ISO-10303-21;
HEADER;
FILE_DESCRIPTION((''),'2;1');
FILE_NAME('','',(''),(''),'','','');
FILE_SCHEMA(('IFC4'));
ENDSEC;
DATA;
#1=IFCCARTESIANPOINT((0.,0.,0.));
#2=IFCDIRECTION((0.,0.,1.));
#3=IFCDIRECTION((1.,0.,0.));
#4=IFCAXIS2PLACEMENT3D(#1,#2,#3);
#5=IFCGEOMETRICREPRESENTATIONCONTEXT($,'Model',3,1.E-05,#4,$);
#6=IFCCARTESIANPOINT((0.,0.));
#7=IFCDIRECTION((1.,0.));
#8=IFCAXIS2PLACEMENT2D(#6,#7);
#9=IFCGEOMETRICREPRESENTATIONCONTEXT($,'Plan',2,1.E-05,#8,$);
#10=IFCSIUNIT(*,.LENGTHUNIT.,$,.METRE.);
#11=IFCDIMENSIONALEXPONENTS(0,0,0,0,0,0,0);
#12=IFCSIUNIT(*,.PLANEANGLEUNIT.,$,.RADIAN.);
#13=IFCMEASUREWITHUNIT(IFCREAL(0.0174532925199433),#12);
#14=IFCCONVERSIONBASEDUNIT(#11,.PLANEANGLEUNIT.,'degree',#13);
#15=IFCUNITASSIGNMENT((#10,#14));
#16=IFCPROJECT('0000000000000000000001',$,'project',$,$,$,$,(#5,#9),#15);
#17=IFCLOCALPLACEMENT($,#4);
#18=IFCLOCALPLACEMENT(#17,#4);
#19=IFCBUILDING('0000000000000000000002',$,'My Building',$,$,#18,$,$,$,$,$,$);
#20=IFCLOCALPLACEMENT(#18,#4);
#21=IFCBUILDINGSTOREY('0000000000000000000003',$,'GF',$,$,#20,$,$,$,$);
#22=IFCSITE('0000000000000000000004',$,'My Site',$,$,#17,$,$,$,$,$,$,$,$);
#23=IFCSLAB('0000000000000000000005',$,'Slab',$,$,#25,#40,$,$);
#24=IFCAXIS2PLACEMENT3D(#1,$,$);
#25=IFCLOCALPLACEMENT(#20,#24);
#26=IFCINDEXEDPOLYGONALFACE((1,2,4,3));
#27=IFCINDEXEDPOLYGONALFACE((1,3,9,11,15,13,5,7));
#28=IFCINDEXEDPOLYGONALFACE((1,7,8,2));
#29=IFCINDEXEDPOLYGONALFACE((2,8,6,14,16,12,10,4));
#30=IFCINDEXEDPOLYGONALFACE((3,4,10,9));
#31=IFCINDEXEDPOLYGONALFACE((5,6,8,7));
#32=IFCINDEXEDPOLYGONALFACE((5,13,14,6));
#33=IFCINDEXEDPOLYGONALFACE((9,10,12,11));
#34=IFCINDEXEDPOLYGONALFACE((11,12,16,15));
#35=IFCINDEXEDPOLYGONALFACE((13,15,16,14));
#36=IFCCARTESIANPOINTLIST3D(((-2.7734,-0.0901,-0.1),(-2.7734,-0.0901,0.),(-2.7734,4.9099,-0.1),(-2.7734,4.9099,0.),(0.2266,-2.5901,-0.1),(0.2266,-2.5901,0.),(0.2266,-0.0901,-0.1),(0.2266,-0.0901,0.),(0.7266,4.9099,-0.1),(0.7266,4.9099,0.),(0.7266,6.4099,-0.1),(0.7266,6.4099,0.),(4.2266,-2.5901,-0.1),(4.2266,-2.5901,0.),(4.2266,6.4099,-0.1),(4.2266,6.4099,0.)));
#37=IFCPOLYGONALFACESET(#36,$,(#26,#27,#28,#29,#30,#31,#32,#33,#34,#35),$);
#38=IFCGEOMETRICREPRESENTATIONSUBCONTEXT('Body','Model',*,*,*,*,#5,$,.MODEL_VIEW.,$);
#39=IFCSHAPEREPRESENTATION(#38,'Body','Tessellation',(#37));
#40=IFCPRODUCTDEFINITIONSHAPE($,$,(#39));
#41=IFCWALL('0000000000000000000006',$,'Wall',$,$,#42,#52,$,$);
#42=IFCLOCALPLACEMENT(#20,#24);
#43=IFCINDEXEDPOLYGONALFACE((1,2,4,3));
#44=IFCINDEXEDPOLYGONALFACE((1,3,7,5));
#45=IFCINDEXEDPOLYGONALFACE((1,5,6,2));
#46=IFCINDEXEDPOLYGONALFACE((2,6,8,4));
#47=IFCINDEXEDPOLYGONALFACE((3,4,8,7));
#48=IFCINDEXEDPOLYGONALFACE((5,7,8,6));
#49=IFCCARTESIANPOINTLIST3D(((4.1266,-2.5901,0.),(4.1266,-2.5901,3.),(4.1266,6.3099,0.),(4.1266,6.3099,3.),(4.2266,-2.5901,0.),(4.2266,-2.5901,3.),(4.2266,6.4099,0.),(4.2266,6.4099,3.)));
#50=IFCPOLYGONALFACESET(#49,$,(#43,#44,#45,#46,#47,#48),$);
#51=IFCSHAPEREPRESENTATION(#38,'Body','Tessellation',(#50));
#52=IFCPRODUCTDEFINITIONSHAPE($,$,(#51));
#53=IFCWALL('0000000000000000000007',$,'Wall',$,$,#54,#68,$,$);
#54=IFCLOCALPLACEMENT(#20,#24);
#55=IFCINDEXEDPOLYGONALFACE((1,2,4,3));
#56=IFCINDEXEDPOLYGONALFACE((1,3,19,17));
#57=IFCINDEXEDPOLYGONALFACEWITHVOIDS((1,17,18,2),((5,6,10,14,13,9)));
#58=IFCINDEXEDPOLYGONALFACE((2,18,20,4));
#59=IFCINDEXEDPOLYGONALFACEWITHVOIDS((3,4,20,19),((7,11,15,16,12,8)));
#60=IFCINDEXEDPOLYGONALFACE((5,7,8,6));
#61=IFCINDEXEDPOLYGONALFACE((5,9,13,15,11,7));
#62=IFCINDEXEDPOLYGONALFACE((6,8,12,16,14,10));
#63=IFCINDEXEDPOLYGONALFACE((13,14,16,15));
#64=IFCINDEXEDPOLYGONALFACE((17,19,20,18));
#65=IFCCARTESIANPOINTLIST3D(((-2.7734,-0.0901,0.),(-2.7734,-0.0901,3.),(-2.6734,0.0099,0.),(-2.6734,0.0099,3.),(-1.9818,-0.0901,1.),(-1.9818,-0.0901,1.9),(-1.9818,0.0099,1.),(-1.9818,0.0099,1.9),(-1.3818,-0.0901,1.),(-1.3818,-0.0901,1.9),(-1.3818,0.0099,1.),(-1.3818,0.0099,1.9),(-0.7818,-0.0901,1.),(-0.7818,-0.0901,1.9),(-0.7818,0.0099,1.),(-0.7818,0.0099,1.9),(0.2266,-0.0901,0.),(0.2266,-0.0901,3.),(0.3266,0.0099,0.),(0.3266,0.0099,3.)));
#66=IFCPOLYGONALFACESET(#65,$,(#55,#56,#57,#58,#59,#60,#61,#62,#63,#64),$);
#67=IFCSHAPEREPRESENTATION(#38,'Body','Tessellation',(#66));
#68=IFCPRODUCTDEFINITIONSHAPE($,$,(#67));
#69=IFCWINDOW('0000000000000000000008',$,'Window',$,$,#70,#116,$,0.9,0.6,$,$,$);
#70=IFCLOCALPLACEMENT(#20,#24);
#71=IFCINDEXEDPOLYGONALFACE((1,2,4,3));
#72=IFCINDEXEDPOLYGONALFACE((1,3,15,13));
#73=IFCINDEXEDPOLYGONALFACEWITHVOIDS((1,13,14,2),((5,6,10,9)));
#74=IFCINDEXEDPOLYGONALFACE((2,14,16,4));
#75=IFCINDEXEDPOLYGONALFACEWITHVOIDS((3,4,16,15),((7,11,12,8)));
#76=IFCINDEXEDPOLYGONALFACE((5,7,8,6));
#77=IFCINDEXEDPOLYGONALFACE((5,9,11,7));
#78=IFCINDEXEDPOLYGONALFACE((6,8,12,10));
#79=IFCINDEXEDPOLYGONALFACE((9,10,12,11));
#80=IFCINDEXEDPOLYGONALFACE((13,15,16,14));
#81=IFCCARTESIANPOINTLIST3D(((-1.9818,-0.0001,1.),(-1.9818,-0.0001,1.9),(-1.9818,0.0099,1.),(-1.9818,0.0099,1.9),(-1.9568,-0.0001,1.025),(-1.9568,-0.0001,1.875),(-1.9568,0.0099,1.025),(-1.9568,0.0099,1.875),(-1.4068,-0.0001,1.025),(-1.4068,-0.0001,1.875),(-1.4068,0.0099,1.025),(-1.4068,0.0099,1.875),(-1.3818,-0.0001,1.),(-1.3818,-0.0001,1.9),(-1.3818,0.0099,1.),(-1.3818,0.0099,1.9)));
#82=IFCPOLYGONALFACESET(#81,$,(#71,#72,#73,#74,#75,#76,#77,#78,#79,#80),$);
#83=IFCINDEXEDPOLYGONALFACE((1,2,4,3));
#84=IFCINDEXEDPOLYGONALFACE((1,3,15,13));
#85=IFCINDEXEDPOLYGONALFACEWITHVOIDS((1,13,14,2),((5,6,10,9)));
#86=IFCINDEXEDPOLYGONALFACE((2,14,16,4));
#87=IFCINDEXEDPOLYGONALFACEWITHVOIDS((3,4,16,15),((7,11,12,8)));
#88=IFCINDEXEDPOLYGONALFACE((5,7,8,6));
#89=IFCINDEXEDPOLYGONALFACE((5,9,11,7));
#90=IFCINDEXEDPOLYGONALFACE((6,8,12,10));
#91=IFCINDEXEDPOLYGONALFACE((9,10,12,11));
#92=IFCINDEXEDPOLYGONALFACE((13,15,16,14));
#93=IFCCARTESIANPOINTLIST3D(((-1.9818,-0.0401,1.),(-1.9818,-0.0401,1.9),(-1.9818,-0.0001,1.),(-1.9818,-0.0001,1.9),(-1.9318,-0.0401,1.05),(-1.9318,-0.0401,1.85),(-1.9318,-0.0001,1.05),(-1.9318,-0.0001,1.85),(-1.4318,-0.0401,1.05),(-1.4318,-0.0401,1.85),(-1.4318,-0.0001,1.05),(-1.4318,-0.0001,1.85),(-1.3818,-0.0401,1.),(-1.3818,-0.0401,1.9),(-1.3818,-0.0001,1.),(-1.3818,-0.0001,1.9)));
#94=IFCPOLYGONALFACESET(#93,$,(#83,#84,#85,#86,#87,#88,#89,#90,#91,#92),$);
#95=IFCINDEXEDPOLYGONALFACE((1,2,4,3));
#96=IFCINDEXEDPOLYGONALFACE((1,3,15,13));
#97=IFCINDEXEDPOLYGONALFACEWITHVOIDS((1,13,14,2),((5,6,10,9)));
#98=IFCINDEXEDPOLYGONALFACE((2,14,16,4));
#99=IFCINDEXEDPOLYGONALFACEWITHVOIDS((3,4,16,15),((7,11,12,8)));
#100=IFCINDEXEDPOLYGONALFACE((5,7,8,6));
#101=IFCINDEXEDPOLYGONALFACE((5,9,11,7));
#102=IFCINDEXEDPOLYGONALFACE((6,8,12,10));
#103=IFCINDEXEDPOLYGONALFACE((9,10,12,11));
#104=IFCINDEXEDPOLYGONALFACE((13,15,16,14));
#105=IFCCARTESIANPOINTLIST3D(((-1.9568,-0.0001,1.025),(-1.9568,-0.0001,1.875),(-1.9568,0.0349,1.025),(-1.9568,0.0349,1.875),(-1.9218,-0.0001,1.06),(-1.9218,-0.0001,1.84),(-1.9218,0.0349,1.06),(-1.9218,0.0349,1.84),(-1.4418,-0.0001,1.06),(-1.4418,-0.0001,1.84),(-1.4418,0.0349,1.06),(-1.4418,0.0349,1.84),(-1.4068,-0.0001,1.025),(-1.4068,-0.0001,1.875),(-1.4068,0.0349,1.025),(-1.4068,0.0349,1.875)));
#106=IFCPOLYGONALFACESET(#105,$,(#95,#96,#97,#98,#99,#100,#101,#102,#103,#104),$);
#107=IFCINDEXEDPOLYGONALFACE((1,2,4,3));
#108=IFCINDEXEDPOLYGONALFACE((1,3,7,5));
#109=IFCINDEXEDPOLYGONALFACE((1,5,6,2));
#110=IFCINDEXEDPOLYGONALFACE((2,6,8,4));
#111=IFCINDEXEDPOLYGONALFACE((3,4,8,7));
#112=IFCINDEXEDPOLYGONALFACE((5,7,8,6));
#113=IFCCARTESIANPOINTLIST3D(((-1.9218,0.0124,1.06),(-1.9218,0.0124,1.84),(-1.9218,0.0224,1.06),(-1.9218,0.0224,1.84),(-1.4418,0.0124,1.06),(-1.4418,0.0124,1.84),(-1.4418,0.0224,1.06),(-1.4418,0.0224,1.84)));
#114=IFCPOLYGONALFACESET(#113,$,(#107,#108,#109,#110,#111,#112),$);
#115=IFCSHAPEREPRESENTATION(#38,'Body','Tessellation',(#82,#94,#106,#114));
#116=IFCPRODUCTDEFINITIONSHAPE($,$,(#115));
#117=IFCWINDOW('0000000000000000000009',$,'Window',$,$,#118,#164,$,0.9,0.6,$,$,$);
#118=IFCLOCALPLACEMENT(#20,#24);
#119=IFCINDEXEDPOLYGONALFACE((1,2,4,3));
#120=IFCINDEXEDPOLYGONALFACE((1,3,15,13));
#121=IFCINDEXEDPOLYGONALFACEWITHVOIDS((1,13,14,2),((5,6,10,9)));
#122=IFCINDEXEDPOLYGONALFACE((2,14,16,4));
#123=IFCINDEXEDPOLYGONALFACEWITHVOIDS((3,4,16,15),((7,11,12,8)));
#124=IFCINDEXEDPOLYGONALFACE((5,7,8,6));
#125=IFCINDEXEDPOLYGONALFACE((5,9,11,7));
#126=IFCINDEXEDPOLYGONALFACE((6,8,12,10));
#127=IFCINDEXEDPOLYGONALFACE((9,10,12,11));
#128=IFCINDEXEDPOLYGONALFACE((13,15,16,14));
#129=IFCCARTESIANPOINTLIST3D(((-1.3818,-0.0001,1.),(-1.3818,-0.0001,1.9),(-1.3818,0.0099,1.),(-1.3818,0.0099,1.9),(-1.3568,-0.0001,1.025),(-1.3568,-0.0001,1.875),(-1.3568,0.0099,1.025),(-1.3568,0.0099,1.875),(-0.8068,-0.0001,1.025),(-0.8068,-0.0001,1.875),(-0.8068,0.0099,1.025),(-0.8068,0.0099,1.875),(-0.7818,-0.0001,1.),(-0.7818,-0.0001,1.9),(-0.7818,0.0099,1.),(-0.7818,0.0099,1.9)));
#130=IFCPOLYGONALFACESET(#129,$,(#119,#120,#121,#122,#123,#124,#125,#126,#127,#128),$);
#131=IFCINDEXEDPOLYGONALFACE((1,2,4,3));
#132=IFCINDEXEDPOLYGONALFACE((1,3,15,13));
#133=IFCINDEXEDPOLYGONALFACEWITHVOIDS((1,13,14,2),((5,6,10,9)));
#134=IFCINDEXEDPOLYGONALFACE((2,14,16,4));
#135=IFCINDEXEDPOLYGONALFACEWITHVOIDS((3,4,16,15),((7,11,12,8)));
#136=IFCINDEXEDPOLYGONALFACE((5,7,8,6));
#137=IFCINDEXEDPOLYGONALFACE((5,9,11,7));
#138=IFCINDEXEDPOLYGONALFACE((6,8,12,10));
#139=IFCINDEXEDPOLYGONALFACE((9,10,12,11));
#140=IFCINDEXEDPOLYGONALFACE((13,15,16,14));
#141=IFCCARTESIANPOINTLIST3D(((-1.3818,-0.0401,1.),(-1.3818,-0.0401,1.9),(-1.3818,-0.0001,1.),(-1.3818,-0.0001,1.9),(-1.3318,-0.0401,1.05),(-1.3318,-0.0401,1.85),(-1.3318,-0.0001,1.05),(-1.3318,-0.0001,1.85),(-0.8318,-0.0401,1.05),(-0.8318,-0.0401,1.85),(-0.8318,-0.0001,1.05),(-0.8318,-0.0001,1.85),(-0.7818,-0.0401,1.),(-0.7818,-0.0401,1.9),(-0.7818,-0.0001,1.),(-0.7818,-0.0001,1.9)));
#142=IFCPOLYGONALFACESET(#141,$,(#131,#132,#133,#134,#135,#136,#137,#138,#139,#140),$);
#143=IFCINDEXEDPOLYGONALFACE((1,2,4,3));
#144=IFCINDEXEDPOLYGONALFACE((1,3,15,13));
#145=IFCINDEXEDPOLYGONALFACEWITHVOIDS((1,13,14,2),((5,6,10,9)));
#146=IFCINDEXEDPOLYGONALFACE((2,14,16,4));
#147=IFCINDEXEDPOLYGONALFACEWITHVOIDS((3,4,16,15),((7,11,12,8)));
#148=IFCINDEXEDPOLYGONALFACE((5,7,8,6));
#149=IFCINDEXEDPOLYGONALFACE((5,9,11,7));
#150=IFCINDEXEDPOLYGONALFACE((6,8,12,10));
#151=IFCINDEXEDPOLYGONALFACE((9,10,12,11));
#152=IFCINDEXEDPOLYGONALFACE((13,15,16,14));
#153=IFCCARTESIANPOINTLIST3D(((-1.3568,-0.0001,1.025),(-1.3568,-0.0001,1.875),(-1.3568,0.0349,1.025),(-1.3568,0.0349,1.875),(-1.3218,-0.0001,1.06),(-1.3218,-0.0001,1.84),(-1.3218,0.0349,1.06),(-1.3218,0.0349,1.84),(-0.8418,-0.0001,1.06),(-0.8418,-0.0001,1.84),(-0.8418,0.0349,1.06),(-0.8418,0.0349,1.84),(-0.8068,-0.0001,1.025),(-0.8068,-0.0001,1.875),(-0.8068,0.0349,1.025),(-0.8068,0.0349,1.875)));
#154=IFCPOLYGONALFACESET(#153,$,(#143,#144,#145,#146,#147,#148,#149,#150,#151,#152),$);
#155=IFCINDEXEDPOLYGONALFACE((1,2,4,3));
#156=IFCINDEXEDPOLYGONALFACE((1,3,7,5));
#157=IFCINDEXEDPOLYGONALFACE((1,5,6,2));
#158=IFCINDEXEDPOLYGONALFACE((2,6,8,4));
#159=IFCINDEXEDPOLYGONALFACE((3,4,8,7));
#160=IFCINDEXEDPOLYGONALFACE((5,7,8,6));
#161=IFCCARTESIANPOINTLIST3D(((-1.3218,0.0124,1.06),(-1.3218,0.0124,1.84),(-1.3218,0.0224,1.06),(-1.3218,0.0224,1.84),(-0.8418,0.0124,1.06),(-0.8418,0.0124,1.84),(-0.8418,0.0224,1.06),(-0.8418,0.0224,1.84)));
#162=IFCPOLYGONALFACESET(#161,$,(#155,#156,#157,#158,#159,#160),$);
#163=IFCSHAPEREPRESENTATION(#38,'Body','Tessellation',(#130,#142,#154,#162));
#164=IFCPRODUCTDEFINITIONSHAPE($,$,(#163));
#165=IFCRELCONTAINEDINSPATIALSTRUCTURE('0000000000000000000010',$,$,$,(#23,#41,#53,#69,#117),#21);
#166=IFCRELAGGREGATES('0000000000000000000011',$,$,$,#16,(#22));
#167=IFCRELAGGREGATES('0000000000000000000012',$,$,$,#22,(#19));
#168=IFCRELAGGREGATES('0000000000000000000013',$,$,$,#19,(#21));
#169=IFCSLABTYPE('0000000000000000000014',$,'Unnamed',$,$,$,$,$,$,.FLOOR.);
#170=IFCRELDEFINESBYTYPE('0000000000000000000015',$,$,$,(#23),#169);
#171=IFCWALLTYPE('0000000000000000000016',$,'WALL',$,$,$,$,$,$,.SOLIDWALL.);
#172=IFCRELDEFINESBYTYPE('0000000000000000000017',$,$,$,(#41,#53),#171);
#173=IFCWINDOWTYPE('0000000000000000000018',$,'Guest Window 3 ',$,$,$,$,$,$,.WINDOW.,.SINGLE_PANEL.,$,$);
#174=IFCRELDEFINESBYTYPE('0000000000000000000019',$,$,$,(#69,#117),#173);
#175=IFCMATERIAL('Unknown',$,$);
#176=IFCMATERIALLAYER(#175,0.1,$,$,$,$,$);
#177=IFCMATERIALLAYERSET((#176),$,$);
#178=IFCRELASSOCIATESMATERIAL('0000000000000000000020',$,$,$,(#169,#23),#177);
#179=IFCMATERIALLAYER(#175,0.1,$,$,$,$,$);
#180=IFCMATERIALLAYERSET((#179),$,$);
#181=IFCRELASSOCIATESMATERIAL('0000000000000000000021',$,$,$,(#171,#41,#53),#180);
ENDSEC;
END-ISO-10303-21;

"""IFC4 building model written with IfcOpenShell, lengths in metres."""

from ifc_helpers import new_model, entity, si_unit, converted_unit, frame, origin_with_axes, origin_2d_with_axis, place, context, subcontext, project, spatial, line, indexed_curve, outline, extrude, shape, source, transform, mapped, material, layer, layer_set, layer_usage, type_object, type_shapes, element, fill, save


model = new_model("IFC4")

# Units and contexts
model_context = context("Model", 3, precision=1e-05, world=origin_with_axes())
plan_context = context("Plan", 2, precision=1e-05, world=origin_2d_with_axis())
body_context_1 = subcontext(model_context, "Body", "Model", "MODEL_VIEW")
body_context_2 = subcontext(plan_context, "Body", "Plan", "PLAN_VIEW")
ifc_project = project(units=[si_unit("LENGTHUNIT", "METRE"), converted_unit("PLANEANGLEUNIT", "degree", entity("IfcReal", 0.0174532925199433), si_unit("PLANEANGLEUNIT", "RADIAN"), dimensions=[0, 0, 0, 0, 0, 0, 0])], contexts=[model_context, plan_context])

# Site, building, storey
site_placement = place(None, origin_with_axes())
site = spatial("IfcSite", under=ifc_project, at=site_placement, Name="My Site")
building_placement = place(site_placement, origin_with_axes())
building = spatial("IfcBuilding", under=site, at=building_placement, Name="My Building")
storey_placement = place(building_placement, origin_with_axes())
storey = spatial("IfcBuildingStorey", under=building, at=storey_placement, Name="GF")

# Slab
ifc_material = material(Name="Unknown")
ifc_layer_1 = layer(ifc_material, 0.1)
ifc_layer_set_1 = layer_set([ifc_layer_1])
ifc_layer_usage_1 = layer_usage(ifc_layer_set_1, "AXIS3", "POSITIVE", -0.1)
slab_type = type_object("IfcSlabType", Name="Unnamed", PredefinedType="FLOOR", material=ifc_layer_set_1)
slab_placement = place(storey_placement, frame((4.2266, -2.5901, 0.0), z_axis=(0.0, 0.0, 1.0), x_axis=(1.0, 0.0, 0.0)))
element("IfcSlab", 1, at=slab_placement, inside=storey, type_object=slab_type, material=ifc_layer_usage_1, Name="Slab", context=body_context_1, shape_type="SweptSolid", body=[
    extrude(outline(indexed_curve([(0.0, 0.0), (0.0, 9.0), (-3.5, 9.0), (-3.5, 7.5), (-7.0, 7.5), (-7.0, 2.5), (-4.0, 2.5), (-4.0, 0.0), (0.0, 0.0)])), frame((0.0, 0.0, -0.1), z_axis=(0.0, 0.0, 1.0), x_axis=(1.0, 0.0, 0.0)), (0.0, 0.0, 1.0), 0.1),
])

# Shared definitions
ifc_layer_2 = layer(ifc_material, 0.1)
ifc_layer_set_2 = layer_set([ifc_layer_2])
wall_type = type_object("IfcWallType", Name="WALL", PredefinedType="SOLIDWALL", material=ifc_layer_set_2)

# Wall
ifc_layer_usage_2 = layer_usage(ifc_layer_set_2, "AXIS2", "POSITIVE", 0.0)
wall_1_placement = place(storey_placement, frame((4.2266, -2.5901, 0.0), z_axis=(0.0, 0.0, 1.0), x_axis=(0.0, 1.0, 0.0)))
element("IfcWall", 2, at=wall_1_placement, inside=storey, type_object=wall_type, material=ifc_layer_usage_2, Name="Wall", context=body_context_1, shape_type="SweptSolid", body=[
    extrude(outline(indexed_curve([(0.0, 0.0), (0.0, 0.1), (8.9, 0.1), (9.0, 0.0)], segments=[line(1, 2, 3, 4, 1)])), origin_with_axes(), (0.0, 0.0, 1.0), 3.0),
])

# Wall, openings, windows
ifc_layer_usage_3 = layer_usage(ifc_layer_set_2, "AXIS2", "POSITIVE", 0.0)
wall_2_placement = place(storey_placement, frame((-2.7734, -0.0901, 0.0), z_axis=(0.0, 0.0, 1.0), x_axis=(1.0, 0.0, 0.0)))
wall_2 = element("IfcWall", 3, at=wall_2_placement, inside=storey, type_object=wall_type, material=ifc_layer_usage_3, Name="Wall", context=body_context_1, shape_type="SweptSolid", body=[
    extrude(outline(indexed_curve([(0.0, 0.0), (0.1, 0.1), (3.1, 0.1), (3.0, 0.0)], segments=[line(1, 2, 3, 4, 1)])), origin_with_axes(), (0.0, 0.0, 1.0), 3.0),
])
shared_shape_1 = source(origin_with_axes(), body_context_1, "Body", "SweptSolid", [
    extrude(outline(indexed_curve([(0.0, 0.0), (0.6, 0.0), (0.6, 0.9), (0.0, 0.9)], segments=[line(1, 2, 3, 4, 1)])), frame((0.0, -0.6, 0.0), z_axis=(0.0, -1.0, 0.0), x_axis=(1.0, 0.0, 0.0)), (0.0, 0.0, -1.0), 1.2),
])
opening_1_placement = place(wall_2_placement, frame((0.7916, 0.0, 1.0), z_axis=(0.0, 0.0, 1.0), x_axis=(1.0, 0.0, 0.0)))
opening_1 = element("IfcOpeningElement", 4, at=opening_1_placement, cuts=wall_2, PredefinedType="OPENING", context=body_context_1, shape_type="MappedRepresentation", body=[
    mapped(shared_shape_1, transform((0.0, 0.0, 0.0), x_axis=(1.0, 0.0, 0.0), y_axis=(0.0, 1.0, 0.0), z_axis=(0.0, 0.0, 1.0), scale=1.0)),
])
opening_2_placement = place(wall_2_placement, frame((1.3916, 0.0, 1.0), z_axis=(0.0, 0.0, 1.0), x_axis=(1.0, 0.0, 0.0)))
opening_2 = element("IfcOpeningElement", 5, at=opening_2_placement, cuts=wall_2, PredefinedType="OPENING", context=body_context_1, shape_type="MappedRepresentation", body=[
    mapped(shared_shape_1, transform((0.0, 0.0, 0.0), x_axis=(1.0, 0.0, 0.0), y_axis=(0.0, 1.0, 0.0), z_axis=(0.0, 0.0, 1.0), scale=1.0)),
])
window_type_1 = type_object("IfcWindowType", Name="Guest Window 3 ", PartitioningType="SINGLE_PANEL", PredefinedType="WINDOW")
shared_shape_2 = source(origin_with_axes(), body_context_1, "Body", "SweptSolid", [
    extrude(outline(indexed_curve([(0.0, 0.0), (0.6, 0.0), (0.6, 0.9), (0.0, 0.9)], segments=[line(1, 2, 3, 4, 1)]), holes=[indexed_curve([(0.025, 0.025), (0.575, 0.025), (0.575, 0.875), (0.025, 0.875)], segments=[line(1, 2, 3, 4, 1)])]), frame((0.0, 0.09, 0.0), z_axis=(0.0, -1.0, 0.0), x_axis=(1.0, 0.0, 0.0)), (0.0, 0.0, -1.0), 0.01),
    extrude(outline(indexed_curve([(0.0, 0.0), (0.6, 0.0), (0.6, 0.9), (0.0, 0.9)], segments=[line(1, 2, 3, 4, 1)]), holes=[indexed_curve([(0.05, 0.05), (0.55, 0.05), (0.55, 0.85), (0.05, 0.85)], segments=[line(1, 2, 3, 4, 1)])]), frame((0.0, 0.05, 0.0), z_axis=(0.0, -1.0, 0.0), x_axis=(1.0, 0.0, 0.0)), (0.0, 0.0, -1.0), 0.04),
    extrude(outline(indexed_curve([(0.0, 0.0), (0.55, 0.0), (0.55, 0.85), (0.0, 0.85)], segments=[line(1, 2, 3, 4, 1)]), holes=[indexed_curve([(0.035, 0.035), (0.515, 0.035), (0.515, 0.815), (0.035, 0.815)], segments=[line(1, 2, 3, 4, 1)])]), frame((0.025, 0.09, 0.025), z_axis=(0.0, -1.0, 0.0), x_axis=(1.0, 0.0, 0.0)), (0.0, 0.0, -1.0), 0.035),
    extrude(outline(indexed_curve([(0.035, 0.035), (0.515, 0.035), (0.515, 0.815), (0.035, 0.815)], segments=[line(1, 2, 3, 4, 1)])), frame((0.025, 0.1025, 0.025), z_axis=(0.0, -1.0, 0.0), x_axis=(1.0, 0.0, 0.0)), (0.0, 0.0, -1.0), 0.01),
])
shared_shape_3 = source(origin_with_axes(), body_context_2, "Body", "Curve2D", [
    entity("IfcIndexedPolyCurve", entity("IfcCartesianPointList2D", [[0.05, 0.05], [0.55, 0.05]])),
    entity("IfcIndexedPolyCurve", entity("IfcCartesianPointList2D", [[0.0, 0.1], [0.025, 0.1], [0.025, 0.09], [0.05, 0.09], [0.05, 0.05], [0.0, 0.05]]), [entity("IfcLineIndex", [1, 2, 3, 4, 5, 6, 1])]),
    entity("IfcIndexedPolyCurve", entity("IfcCartesianPointList2D", [[0.6, 0.1], [0.575, 0.1], [0.575, 0.09], [0.55, 0.09], [0.55, 0.05], [0.6, 0.05]]), [entity("IfcLineIndex", [1, 2, 3, 4, 5, 6, 1])]),
    entity("IfcIndexedPolyCurve", entity("IfcCartesianPointList2D", [[0.025, 0.09], [0.06, 0.09], [0.06, 0.125], [0.025, 0.125]]), [entity("IfcLineIndex", [1, 2, 3, 4, 1])]),
    entity("IfcIndexedPolyCurve", entity("IfcCartesianPointList2D", [[0.575, 0.09], [0.54, 0.09], [0.54, 0.125], [0.575, 0.125]]), [entity("IfcLineIndex", [1, 2, 3, 4, 1])]),
    entity("IfcIndexedPolyCurve", entity("IfcCartesianPointList2D", [[0.06, 0.09], [0.54, 0.09]])),
    entity("IfcIndexedPolyCurve", entity("IfcCartesianPointList2D", [[0.06, 0.125], [0.54, 0.125]])),
    entity("IfcIndexedPolyCurve", entity("IfcCartesianPointList2D", [[0.06, 0.1075], [0.54, 0.1075]])),
])
type_shapes(window_type_1, [shared_shape_2, shared_shape_3])
window_1_placement = place(opening_1_placement, origin_with_axes())
window_1 = element("IfcWindow", 6, at=window_1_placement, inside=storey, type_object=window_type_1, Name="Window", OverallHeight=0.9, OverallWidth=0.6, shapes=[
    shape(body_context_1, "Body", "MappedRepresentation", [mapped(shared_shape_2, transform((0.0, 0.0, 0.0), x_axis=(1.0, 0.0, 0.0), y_axis=(0.0, 1.0, 0.0), z_axis=(0.0, 0.0, 1.0), scale=1.0))]),
    shape(body_context_2, "Body", "MappedRepresentation", [mapped(shared_shape_3, transform((0.0, 0.0, 0.0), x_axis=(1.0, 0.0, 0.0), y_axis=(0.0, 1.0, 0.0), z_axis=(0.0, 0.0, 1.0), scale=1.0))]),
])
fill(opening_1, window_1)
window_2_placement = place(opening_2_placement, origin_with_axes())
window_2 = element("IfcWindow", 7, at=window_2_placement, inside=storey, type_object=window_type_1, Name="Window", OverallHeight=0.9, OverallWidth=0.6, shapes=[
    shape(body_context_1, "Body", "MappedRepresentation", [mapped(shared_shape_2, transform((0.0, 0.0, 0.0), x_axis=(1.0, 0.0, 0.0), y_axis=(0.0, 1.0, 0.0), z_axis=(0.0, 0.0, 1.0), scale=1.0))]),
    shape(body_context_2, "Body", "MappedRepresentation", [mapped(shared_shape_3, transform((0.0, 0.0, 0.0), x_axis=(1.0, 0.0, 0.0), y_axis=(0.0, 1.0, 0.0), z_axis=(0.0, 0.0, 1.0), scale=1.0))]),
])
fill(opening_2, window_2)

save(model, "model.ifc")
